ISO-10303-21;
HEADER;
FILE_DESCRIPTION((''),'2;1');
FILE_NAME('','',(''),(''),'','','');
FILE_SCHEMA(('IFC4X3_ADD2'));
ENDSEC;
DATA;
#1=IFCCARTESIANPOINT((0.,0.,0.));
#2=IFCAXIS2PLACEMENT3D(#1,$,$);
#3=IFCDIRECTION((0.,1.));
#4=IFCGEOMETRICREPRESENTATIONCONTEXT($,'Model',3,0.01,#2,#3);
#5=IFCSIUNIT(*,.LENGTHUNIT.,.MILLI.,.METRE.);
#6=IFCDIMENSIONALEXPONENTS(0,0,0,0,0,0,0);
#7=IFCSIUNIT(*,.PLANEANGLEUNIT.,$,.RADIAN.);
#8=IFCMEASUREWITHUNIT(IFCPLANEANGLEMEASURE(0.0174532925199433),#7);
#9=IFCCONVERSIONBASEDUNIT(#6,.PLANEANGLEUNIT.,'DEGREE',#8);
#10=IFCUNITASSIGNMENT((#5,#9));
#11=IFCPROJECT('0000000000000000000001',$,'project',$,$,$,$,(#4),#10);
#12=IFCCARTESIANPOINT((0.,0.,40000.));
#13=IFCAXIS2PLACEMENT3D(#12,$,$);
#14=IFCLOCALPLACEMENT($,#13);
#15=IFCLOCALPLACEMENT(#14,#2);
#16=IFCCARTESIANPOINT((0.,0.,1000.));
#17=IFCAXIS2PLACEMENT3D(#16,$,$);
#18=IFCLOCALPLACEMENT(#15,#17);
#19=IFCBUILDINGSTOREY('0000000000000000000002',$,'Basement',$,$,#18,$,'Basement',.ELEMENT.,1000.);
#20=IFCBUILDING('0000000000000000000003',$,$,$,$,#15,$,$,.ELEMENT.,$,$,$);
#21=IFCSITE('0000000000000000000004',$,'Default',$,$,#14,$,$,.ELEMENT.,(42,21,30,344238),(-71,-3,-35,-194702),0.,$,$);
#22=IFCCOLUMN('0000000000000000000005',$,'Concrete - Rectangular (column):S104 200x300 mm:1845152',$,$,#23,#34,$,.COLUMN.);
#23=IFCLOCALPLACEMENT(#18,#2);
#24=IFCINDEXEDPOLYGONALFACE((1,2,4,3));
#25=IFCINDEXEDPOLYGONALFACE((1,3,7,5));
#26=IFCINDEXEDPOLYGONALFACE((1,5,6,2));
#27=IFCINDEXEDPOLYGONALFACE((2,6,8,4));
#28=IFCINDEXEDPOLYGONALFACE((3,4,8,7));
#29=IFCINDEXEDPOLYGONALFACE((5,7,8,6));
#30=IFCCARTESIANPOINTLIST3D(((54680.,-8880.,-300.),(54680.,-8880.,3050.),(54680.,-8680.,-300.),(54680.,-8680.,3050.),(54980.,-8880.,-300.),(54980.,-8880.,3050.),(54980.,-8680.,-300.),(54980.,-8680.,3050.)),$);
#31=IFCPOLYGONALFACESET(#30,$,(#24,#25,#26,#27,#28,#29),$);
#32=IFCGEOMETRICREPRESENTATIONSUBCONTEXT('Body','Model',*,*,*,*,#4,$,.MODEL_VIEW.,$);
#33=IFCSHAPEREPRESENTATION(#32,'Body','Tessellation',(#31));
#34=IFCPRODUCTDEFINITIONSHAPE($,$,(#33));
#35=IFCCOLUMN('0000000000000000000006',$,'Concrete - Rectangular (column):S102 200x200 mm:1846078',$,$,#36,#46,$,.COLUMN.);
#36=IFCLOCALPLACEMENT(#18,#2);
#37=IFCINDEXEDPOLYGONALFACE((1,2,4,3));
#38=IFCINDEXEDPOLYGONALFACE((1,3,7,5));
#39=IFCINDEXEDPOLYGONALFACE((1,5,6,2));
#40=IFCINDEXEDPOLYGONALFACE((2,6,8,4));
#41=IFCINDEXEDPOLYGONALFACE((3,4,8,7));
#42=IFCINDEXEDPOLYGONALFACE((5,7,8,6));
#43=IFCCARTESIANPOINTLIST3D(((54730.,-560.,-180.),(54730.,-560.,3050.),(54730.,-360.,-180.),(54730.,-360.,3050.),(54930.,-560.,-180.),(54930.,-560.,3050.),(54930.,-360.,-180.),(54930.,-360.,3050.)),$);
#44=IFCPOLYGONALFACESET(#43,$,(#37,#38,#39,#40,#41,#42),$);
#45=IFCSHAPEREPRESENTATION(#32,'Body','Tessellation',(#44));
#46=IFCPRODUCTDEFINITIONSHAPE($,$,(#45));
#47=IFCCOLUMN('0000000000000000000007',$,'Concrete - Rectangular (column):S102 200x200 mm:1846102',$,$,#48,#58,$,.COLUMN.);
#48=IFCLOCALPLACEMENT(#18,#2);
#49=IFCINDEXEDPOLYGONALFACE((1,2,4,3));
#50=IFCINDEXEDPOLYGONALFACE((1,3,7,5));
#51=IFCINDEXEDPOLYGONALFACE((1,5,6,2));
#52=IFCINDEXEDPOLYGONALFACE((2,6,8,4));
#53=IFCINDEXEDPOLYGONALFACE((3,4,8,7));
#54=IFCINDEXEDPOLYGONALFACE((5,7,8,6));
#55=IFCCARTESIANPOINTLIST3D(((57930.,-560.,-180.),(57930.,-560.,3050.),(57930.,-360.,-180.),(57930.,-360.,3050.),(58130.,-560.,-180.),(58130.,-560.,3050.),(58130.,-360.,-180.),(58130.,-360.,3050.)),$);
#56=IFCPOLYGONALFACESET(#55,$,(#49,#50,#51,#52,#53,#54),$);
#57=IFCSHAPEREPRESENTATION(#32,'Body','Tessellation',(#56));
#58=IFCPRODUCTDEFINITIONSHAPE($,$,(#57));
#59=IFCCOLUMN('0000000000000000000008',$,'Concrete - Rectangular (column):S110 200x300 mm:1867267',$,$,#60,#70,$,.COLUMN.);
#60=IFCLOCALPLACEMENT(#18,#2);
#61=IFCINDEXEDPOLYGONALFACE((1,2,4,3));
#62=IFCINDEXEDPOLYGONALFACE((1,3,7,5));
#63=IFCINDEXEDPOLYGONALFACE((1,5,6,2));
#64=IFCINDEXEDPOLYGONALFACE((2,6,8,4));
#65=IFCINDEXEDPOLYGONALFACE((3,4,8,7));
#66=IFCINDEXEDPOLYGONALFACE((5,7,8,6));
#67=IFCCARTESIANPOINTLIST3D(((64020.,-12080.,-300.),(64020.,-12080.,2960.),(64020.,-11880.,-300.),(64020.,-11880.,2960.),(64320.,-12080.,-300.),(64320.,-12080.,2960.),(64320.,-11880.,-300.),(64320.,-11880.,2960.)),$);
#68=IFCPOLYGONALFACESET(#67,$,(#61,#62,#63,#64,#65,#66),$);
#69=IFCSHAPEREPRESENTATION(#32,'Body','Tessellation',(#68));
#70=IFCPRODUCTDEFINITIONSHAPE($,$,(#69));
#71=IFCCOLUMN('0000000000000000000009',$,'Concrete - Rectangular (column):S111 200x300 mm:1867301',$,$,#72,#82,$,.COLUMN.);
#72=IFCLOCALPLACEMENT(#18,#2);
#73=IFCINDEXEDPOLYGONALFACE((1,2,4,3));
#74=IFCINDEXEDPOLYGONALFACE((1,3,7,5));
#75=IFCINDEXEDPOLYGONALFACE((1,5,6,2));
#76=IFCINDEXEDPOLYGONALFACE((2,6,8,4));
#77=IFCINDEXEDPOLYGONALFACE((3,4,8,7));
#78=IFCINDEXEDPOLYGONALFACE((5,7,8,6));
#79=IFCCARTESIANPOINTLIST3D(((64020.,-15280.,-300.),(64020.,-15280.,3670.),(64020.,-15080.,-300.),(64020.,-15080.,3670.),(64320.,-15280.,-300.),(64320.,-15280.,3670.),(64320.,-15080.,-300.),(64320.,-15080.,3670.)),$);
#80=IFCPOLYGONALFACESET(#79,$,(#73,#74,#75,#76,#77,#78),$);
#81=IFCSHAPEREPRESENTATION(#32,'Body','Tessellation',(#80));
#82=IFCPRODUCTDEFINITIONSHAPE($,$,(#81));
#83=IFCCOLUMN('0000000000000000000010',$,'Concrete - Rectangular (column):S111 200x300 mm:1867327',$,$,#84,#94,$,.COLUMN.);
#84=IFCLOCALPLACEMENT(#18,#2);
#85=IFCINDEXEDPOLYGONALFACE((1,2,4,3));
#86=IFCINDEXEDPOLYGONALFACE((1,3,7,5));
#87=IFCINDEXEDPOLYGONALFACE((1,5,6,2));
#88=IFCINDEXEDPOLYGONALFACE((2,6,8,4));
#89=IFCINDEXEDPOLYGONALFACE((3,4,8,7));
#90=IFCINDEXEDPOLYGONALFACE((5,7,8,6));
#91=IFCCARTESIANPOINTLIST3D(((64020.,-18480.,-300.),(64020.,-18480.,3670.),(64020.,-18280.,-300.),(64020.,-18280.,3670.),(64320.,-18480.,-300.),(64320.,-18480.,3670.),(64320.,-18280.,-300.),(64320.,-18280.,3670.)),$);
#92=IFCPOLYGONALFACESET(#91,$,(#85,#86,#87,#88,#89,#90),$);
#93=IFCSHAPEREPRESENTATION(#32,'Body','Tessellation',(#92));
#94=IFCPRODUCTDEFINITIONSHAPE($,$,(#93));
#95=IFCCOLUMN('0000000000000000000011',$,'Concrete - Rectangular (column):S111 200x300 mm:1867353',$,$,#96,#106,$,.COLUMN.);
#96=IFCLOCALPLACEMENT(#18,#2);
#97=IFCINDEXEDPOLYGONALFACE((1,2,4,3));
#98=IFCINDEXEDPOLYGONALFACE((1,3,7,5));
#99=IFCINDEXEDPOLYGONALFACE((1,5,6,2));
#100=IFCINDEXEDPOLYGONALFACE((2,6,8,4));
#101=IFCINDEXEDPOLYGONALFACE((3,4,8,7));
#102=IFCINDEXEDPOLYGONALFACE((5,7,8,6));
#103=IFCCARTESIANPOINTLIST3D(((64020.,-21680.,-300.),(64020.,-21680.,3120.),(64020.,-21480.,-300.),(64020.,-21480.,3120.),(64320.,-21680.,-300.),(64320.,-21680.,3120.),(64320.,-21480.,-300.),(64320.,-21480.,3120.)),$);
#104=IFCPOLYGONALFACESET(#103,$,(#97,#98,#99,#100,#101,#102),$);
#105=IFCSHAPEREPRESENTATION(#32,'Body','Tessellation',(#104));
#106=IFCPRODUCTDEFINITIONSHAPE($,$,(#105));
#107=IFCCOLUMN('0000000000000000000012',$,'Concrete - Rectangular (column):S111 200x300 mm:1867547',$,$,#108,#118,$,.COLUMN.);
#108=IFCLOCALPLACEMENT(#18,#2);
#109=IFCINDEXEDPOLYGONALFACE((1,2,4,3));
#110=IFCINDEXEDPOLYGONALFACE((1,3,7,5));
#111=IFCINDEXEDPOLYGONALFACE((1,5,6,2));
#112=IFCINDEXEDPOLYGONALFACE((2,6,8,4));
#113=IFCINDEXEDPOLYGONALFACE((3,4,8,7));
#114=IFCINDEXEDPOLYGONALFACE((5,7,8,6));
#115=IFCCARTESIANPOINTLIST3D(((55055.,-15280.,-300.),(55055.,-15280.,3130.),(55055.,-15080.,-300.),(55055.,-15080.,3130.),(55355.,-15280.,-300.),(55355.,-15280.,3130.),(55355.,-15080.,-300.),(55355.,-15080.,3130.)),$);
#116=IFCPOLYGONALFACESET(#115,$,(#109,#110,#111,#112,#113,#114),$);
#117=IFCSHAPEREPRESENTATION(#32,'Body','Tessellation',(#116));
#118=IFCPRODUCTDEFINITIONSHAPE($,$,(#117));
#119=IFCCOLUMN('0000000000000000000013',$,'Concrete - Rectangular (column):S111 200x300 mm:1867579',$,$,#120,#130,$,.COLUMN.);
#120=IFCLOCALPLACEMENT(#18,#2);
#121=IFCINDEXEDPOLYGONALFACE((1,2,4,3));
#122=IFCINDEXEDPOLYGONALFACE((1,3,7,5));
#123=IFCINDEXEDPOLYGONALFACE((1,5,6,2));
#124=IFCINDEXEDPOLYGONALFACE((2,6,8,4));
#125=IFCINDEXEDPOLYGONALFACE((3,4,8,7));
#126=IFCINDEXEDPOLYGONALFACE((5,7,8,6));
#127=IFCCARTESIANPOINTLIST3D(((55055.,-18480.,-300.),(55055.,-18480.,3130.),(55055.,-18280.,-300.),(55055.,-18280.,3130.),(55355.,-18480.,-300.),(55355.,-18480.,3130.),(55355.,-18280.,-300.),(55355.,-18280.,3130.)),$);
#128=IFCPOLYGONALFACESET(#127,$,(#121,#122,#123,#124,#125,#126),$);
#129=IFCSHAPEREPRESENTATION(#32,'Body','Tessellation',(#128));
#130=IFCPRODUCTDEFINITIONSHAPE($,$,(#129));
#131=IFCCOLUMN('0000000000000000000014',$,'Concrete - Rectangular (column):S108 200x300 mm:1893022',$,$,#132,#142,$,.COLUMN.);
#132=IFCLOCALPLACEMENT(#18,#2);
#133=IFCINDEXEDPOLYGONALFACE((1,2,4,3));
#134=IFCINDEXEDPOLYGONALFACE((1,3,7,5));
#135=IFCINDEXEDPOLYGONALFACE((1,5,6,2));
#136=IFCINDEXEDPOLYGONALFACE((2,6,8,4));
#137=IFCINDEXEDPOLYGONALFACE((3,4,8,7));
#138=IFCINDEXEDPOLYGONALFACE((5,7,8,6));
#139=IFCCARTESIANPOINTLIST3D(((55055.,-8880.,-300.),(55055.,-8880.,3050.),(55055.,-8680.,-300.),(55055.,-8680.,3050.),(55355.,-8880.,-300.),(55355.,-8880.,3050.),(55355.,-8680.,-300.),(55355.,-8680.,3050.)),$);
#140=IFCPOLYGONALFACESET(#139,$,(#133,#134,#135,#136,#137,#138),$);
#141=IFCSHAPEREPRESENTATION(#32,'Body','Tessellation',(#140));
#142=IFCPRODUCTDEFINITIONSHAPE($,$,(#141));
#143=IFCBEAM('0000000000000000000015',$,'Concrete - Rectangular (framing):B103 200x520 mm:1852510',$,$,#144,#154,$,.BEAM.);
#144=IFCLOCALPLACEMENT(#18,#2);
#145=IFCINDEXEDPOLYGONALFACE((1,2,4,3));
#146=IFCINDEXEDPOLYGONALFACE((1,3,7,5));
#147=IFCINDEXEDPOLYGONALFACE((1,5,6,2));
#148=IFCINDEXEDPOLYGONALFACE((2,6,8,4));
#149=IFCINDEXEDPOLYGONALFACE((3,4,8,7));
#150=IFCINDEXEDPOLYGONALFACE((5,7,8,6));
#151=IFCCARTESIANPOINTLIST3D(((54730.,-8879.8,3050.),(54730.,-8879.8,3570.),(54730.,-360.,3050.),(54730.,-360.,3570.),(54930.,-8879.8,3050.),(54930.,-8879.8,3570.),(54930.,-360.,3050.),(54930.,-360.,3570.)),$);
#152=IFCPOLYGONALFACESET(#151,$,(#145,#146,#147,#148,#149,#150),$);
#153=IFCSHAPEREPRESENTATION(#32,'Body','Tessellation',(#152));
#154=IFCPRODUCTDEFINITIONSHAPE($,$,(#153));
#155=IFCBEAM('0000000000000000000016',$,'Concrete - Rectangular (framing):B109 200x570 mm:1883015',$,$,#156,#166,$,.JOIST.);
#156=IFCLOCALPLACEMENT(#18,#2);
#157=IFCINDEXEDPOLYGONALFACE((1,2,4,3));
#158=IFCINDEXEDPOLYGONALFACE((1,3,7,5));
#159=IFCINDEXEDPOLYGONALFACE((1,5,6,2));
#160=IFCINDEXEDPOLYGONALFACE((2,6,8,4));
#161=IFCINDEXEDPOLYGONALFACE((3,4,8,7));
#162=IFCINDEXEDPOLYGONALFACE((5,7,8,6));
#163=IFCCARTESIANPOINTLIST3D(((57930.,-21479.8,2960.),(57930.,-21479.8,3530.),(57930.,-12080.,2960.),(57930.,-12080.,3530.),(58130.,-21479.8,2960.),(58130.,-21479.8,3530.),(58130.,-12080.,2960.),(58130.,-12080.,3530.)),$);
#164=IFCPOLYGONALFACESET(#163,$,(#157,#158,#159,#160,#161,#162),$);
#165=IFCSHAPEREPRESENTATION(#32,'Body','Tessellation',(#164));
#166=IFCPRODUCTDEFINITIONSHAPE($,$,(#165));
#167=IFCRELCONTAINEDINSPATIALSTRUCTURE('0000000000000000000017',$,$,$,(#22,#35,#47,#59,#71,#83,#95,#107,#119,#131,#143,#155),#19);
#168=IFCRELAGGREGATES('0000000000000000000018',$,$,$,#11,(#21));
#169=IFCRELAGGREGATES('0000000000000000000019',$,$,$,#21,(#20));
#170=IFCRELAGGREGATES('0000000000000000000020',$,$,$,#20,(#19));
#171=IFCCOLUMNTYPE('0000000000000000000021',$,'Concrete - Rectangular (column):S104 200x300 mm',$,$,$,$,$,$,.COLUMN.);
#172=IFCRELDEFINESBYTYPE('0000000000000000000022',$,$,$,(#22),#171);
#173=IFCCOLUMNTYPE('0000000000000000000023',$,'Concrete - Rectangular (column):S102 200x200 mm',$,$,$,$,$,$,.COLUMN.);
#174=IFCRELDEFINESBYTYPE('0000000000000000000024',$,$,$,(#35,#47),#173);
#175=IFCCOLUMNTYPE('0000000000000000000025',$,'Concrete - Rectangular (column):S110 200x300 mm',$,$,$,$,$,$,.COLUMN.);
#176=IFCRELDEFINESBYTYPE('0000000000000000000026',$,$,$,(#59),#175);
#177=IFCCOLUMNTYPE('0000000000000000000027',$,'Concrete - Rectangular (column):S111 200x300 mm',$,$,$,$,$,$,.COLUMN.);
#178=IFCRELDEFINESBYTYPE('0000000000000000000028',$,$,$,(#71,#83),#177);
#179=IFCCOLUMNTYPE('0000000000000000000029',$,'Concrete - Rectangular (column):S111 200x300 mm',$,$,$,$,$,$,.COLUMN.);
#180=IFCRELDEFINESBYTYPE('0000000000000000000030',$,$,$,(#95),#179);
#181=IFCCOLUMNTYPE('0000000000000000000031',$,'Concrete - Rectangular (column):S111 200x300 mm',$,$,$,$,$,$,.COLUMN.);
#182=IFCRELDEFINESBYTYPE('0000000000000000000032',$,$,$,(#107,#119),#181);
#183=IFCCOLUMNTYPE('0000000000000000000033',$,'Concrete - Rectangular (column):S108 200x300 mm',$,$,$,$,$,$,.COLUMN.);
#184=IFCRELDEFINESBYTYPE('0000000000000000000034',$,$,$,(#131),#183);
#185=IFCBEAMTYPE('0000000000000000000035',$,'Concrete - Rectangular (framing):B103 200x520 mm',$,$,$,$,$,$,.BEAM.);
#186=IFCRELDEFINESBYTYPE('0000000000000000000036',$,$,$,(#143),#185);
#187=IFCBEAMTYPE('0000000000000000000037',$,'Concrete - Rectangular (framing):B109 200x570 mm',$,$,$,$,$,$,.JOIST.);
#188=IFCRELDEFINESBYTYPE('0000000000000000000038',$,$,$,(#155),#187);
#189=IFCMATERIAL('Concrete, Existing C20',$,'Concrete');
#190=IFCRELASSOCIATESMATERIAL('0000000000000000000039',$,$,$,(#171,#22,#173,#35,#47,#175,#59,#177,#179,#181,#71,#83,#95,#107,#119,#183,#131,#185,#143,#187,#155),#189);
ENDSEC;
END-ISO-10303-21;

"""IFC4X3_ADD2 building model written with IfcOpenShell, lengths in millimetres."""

from ifc_helpers import new_model, entity, si_unit, converted_unit, direction, frame, frame_2d, origin, origin_2d_with_axis, place, context, subcontext, project, spatial, rectangle, extrude, source, transform, mapped, material, material_profile, profile_set, profile_usage, type_object, type_shapes, element, save


model = new_model("IFC4X3_ADD2")

# Units and contexts
model_context = context("Model", 3, precision=0.01, world=origin(), true_north=direction((0.0, 1.0)))
body_context = subcontext(model_context, "Body", "Model", "MODEL_VIEW")
ifc_project = project(units=[si_unit("LENGTHUNIT", "METRE", prefix="MILLI"), converted_unit("PLANEANGLEUNIT", "DEGREE", entity("IfcPlaneAngleMeasure", 0.0174532925199433), si_unit("PLANEANGLEUNIT", "RADIAN"), dimensions=[0, 0, 0, 0, 0, 0, 0])], contexts=[model_context])

# Site, building, storey
site_placement = place(None, frame((0.0, 0.0, 40000.0)))
site = spatial("IfcSite", under=ifc_project, at=site_placement, Name="Default", CompositionType="ELEMENT", RefLatitude=(42, 21, 30, 344238), RefLongitude=(-71, -3, -35, -194702), RefElevation=0.0)
building_placement = place(site_placement, origin())
building = spatial("IfcBuilding", under=site, at=building_placement, CompositionType="ELEMENT")
storey_placement = place(building_placement, frame((0.0, 0.0, 1000.0)))
storey = spatial("IfcBuildingStorey", under=building, at=storey_placement, Name="Basement", LongName="Basement", CompositionType="ELEMENT", Elevation=1000.0)

# Columns
ifc_material_1 = material(Name="Concrete, Existing C20", Category="Concrete")
ifc_material_profile_1 = material_profile(ifc_material_1, rectangle(XDim=200.0, YDim=300.0, at=frame_2d((0.0, 0.0), x_axis=(1.0, 0.0))), Name="S104 200x300 mm")
ifc_profile_set_1 = profile_set([ifc_material_profile_1], Name="S104 200x300 mm")
ifc_profile_usage_1 = profile_usage(ifc_profile_set_1)
column_type_1 = type_object("IfcColumnType", Name="Concrete - Rectangular (column):S104 200x300 mm", PredefinedType="COLUMN", material=ifc_profile_set_1)
shared_shape_1 = source(origin(), body_context, "Body", "SweptSolid", [
    extrude(rectangle(XDim=200.0, YDim=300.0, at=origin_2d_with_axis()), frame((0.0, 0.0, 700.0), z_axis=(0.0, 0.0, 1.0), x_axis=(-1.0, 0.0, 0.0)), (0.0, 0.0, 1.0), 3350.0),
])
type_shapes(column_type_1, [shared_shape_1])
column_1_placement = place(storey_placement, frame((54830.0, -8780.0, -1000.0), z_axis=(0.0, 0.0, 1.0), x_axis=(0.0, -1.0, 0.0)))
element("IfcColumn", 1, at=column_1_placement, inside=storey, type_object=column_type_1, material=ifc_profile_usage_1, Name="Concrete - Rectangular (column):S104 200x300 mm:1845152", PredefinedType="COLUMN", context=body_context, shape_type="MappedRepresentation", body=[
    mapped(shared_shape_1, transform((0.0, 0.0, 0.0), scale=1.0)),
])
ifc_material_profile_2 = material_profile(ifc_material_1, rectangle(XDim=200.0, YDim=200.0, at=frame_2d((0.0, 0.0), x_axis=(1.0, 0.0))), Name="S102 200x200 mm")
ifc_profile_set_2 = profile_set([ifc_material_profile_2], Name="S102 200x200 mm")
ifc_profile_usage_2 = profile_usage(ifc_profile_set_2)
column_type_2 = type_object("IfcColumnType", Name="Concrete - Rectangular (column):S102 200x200 mm", PredefinedType="COLUMN", material=ifc_profile_set_2)
shared_shape_2 = source(origin(), body_context, "Body", "SweptSolid", [
    extrude(rectangle(XDim=200.0, YDim=200.0, at=origin_2d_with_axis()), frame((0.0, 0.0, 820.0), z_axis=(0.0, 0.0, 1.0), x_axis=(-1.0, 0.0, 0.0)), (0.0, 0.0, 1.0), 3230.0),
])
type_shapes(column_type_2, [shared_shape_2])
for number, where, z_axis, x_axis, name in (
    (2, (54830.0, -460.0, -1000.0), (0.0, 0.0, 1.0), (0.0, -1.0, 0.0), "Concrete - Rectangular (column):S102 200x200 mm:1846078"),
    (3, (58030.0, -460.0, -1000.0), (0.0, 0.0, 1.0), (0.0, -1.0, 0.0), "Concrete - Rectangular (column):S102 200x200 mm:1846102"),
):
    element("IfcColumn", number, at=place(storey_placement, frame(where, z_axis=z_axis, x_axis=x_axis)), inside=storey, type_object=column_type_2, material=ifc_profile_usage_2, Name=name, PredefinedType="COLUMN", context=body_context, shape_type="MappedRepresentation", body=[
        mapped(shared_shape_2, transform((0.0, 0.0, 0.0), scale=1.0)),
    ])
ifc_material_profile_3 = material_profile(ifc_material_1, rectangle(XDim=200.0, YDim=300.0, at=origin_2d_with_axis()), Name="S110 200x300 mm")
ifc_profile_set_3 = profile_set([ifc_material_profile_3], Name="S110 200x300 mm")
ifc_profile_usage_3 = profile_usage(ifc_profile_set_3)
column_type_3 = type_object("IfcColumnType", Name="Concrete - Rectangular (column):S110 200x300 mm", PredefinedType="COLUMN", material=ifc_profile_set_3)
shared_shape_3 = source(origin(), body_context, "Body", "SweptSolid", [
    extrude(rectangle(XDim=200.0, YDim=300.0, at=origin_2d_with_axis()), frame((0.0, 0.0, 700.0), z_axis=(0.0, 0.0, 1.0), x_axis=(-1.0, 0.0, 0.0)), (0.0, 0.0, 1.0), 3260.0),
])
type_shapes(column_type_3, [shared_shape_3])
column_2_placement = place(storey_placement, frame((64170.0, -11980.0, -1000.0), z_axis=(0.0, 0.0, 1.0), x_axis=(0.0, -1.0, 0.0)))
element("IfcColumn", 4, at=column_2_placement, inside=storey, type_object=column_type_3, material=ifc_profile_usage_3, Name="Concrete - Rectangular (column):S110 200x300 mm:1867267", PredefinedType="COLUMN", context=body_context, shape_type="MappedRepresentation", body=[
    mapped(shared_shape_3, transform((0.0, 0.0, 0.0), scale=1.0)),
])
ifc_material_profile_4 = material_profile(ifc_material_1, rectangle(XDim=200.0, YDim=300.0, at=origin_2d_with_axis()), Name="S111 200x300 mm")
ifc_profile_set_4 = profile_set([ifc_material_profile_4], Name="S111 200x300 mm")
ifc_profile_usage_4 = profile_usage(ifc_profile_set_4)
column_type_4 = type_object("IfcColumnType", Name="Concrete - Rectangular (column):S111 200x300 mm", PredefinedType="COLUMN", material=ifc_profile_set_4)
shared_shape_4 = source(origin(), body_context, "Body", "SweptSolid", [
    extrude(rectangle(XDim=200.0, YDim=300.0, at=origin_2d_with_axis()), frame((0.0, 0.0, 700.0), z_axis=(0.0, 0.0, 1.0), x_axis=(-1.0, 0.0, 0.0)), (0.0, 0.0, 1.0), 3970.0),
])
type_shapes(column_type_4, [shared_shape_4])
for number, where, z_axis, x_axis, name in (
    (5, (64170.0, -15180.0, -1000.0), (0.0, 0.0, 1.0), (0.0, -1.0, 0.0), "Concrete - Rectangular (column):S111 200x300 mm:1867301"),
    (6, (64170.0, -18380.0, -1000.0), (0.0, 0.0, 1.0), (0.0, -1.0, 0.0), "Concrete - Rectangular (column):S111 200x300 mm:1867327"),
):
    element("IfcColumn", number, at=place(storey_placement, frame(where, z_axis=z_axis, x_axis=x_axis)), inside=storey, type_object=column_type_4, material=ifc_profile_usage_4, Name=name, PredefinedType="COLUMN", context=body_context, shape_type="MappedRepresentation", body=[
        mapped(shared_shape_4, transform((0.0, 0.0, 0.0), scale=1.0)),
    ])
column_type_5 = type_object("IfcColumnType", Name="Concrete - Rectangular (column):S111 200x300 mm", PredefinedType="COLUMN", material=ifc_profile_set_4)
shared_shape_5 = source(origin(), body_context, "Body", "SweptSolid", [
    extrude(rectangle(XDim=200.0, YDim=300.0, at=origin_2d_with_axis()), frame((0.0, 0.0, 700.0), z_axis=(0.0, 0.0, 1.0), x_axis=(-1.0, 0.0, 0.0)), (0.0, 0.0, 1.0), 3420.0),
])
type_shapes(column_type_5, [shared_shape_5])
column_3_placement = place(storey_placement, frame((64170.0, -21580.0, -1000.0), z_axis=(0.0, 0.0, 1.0), x_axis=(0.0, -1.0, 0.0)))
element("IfcColumn", 7, at=column_3_placement, inside=storey, type_object=column_type_5, material=ifc_profile_usage_4, Name="Concrete - Rectangular (column):S111 200x300 mm:1867353", PredefinedType="COLUMN", context=body_context, shape_type="MappedRepresentation", body=[
    mapped(shared_shape_5, transform((0.0, 0.0, 0.0), scale=1.0)),
])
column_type_6 = type_object("IfcColumnType", Name="Concrete - Rectangular (column):S111 200x300 mm", PredefinedType="COLUMN", material=ifc_profile_set_4)
shared_shape_6 = source(origin(), body_context, "Body", "SweptSolid", [
    extrude(rectangle(XDim=200.0, YDim=300.0, at=origin_2d_with_axis()), frame((0.0, 0.0, 700.0), z_axis=(0.0, 0.0, 1.0), x_axis=(-1.0, 0.0, 0.0)), (0.0, 0.0, 1.0), 3430.0),
])
type_shapes(column_type_6, [shared_shape_6])
for number, where, z_axis, x_axis, name in (
    (8, (55205.0, -15180.0, -1000.0), (0.0, 0.0, 1.0), (0.0, -1.0, 0.0), "Concrete - Rectangular (column):S111 200x300 mm:1867547"),
    (9, (55205.0, -18380.0, -1000.0), (0.0, 0.0, 1.0), (0.0, -1.0, 0.0), "Concrete - Rectangular (column):S111 200x300 mm:1867579"),
):
    element("IfcColumn", number, at=place(storey_placement, frame(where, z_axis=z_axis, x_axis=x_axis)), inside=storey, type_object=column_type_6, material=ifc_profile_usage_4, Name=name, PredefinedType="COLUMN", context=body_context, shape_type="MappedRepresentation", body=[
        mapped(shared_shape_6, transform((0.0, 0.0, 0.0), scale=1.0)),
    ])
ifc_material_profile_5 = material_profile(ifc_material_1, rectangle(XDim=200.0, YDim=300.0, at=origin_2d_with_axis()), Name="S108 200x300 mm")
ifc_profile_set_5 = profile_set([ifc_material_profile_5], Name="S108 200x300 mm")
ifc_profile_usage_5 = profile_usage(ifc_profile_set_5)
column_type_7 = type_object("IfcColumnType", Name="Concrete - Rectangular (column):S108 200x300 mm", PredefinedType="COLUMN", material=ifc_profile_set_5)
shared_shape_7 = source(origin(), body_context, "Body", "SweptSolid", [
    extrude(rectangle(XDim=200.0, YDim=300.0, at=origin_2d_with_axis()), frame((0.0, 0.0, 700.0), z_axis=(0.0, 0.0, 1.0), x_axis=(-1.0, 0.0, 0.0)), (0.0, 0.0, 1.0), 3350.0),
])
type_shapes(column_type_7, [shared_shape_7])
column_4_placement = place(storey_placement, frame((55205.0, -8780.0, -1000.0), z_axis=(0.0, 0.0, 1.0), x_axis=(0.0, -1.0, 0.0)))
element("IfcColumn", 10, at=column_4_placement, inside=storey, type_object=column_type_7, material=ifc_profile_usage_5, Name="Concrete - Rectangular (column):S108 200x300 mm:1893022", PredefinedType="COLUMN", context=body_context, shape_type="MappedRepresentation", body=[
    mapped(shared_shape_7, transform((0.0, 0.0, 0.0), scale=1.0)),
])

# Beams
ifc_material_profile_6 = material_profile(ifc_material_1, rectangle(XDim=8519.8, YDim=200.0, at=origin_2d_with_axis()), Name="B103 200x520 mm")
ifc_profile_set_6 = profile_set([ifc_material_profile_6], Name="B103 200x520 mm")
ifc_profile_usage_6 = profile_usage(ifc_profile_set_6, cardinal=8)
beam_type_1 = type_object("IfcBeamType", Name="Concrete - Rectangular (framing):B103 200x520 mm", PredefinedType="BEAM", material=ifc_profile_set_6)
shared_shape_8 = source(origin(), body_context, "Body", "SweptSolid", [
    extrude(rectangle(XDim=8519.8, YDim=200.0, at=origin_2d_with_axis()), frame((-0.1, 0.0, -260.0), z_axis=(0.0, 0.0, 1.0), x_axis=(-1.0, 0.0, 0.0)), (0.0, 0.0, 1.0), 520.0),
])
type_shapes(beam_type_1, [shared_shape_8])
beam_1_placement = place(storey_placement, frame((54830.0, -4620.0, 3310.0), z_axis=(0.0, 0.0, 1.0), x_axis=(0.0, -1.0, 0.0)))
element("IfcBeam", 11, at=beam_1_placement, inside=storey, type_object=beam_type_1, material=ifc_profile_usage_6, Name="Concrete - Rectangular (framing):B103 200x520 mm:1852510", PredefinedType="BEAM", context=body_context, shape_type="MappedRepresentation", body=[
    mapped(shared_shape_8, transform((0.0, 0.0, 0.0), scale=1.0)),
])
ifc_material_profile_7 = material_profile(ifc_material_1, rectangle(XDim=9399.8, YDim=200.0, at=origin_2d_with_axis()), Name="B109 200x570 mm")
ifc_profile_set_7 = profile_set([ifc_material_profile_7], Name="B109 200x570 mm")
ifc_profile_usage_7 = profile_usage(ifc_profile_set_7, cardinal=8)
beam_type_2 = type_object("IfcBeamType", Name="Concrete - Rectangular (framing):B109 200x570 mm", PredefinedType="JOIST", material=ifc_profile_set_7)
shared_shape_9 = source(origin(), body_context, "Body", "SweptSolid", [
    extrude(rectangle(XDim=9399.8, YDim=200.0, at=origin_2d_with_axis()), frame((-0.1, 0.0, -285.0), z_axis=(0.0, 0.0, 1.0), x_axis=(-1.0, 0.0, 0.0)), (0.0, 0.0, 1.0), 570.0),
])
type_shapes(beam_type_2, [shared_shape_9])
beam_2_placement = place(storey_placement, frame((58030.0, -16780.0, 3245.0), z_axis=(0.0, 0.0, 1.0), x_axis=(0.0, -1.0, 0.0)))
element("IfcBeam", 12, at=beam_2_placement, inside=storey, type_object=beam_type_2, material=ifc_profile_usage_7, Name="Concrete - Rectangular (framing):B109 200x570 mm:1883015", PredefinedType="JOIST", context=body_context, shape_type="MappedRepresentation", body=[
    mapped(shared_shape_9, transform((0.0, 0.0, 0.0), scale=1.0)),
])

save(model, "model.ifc")
